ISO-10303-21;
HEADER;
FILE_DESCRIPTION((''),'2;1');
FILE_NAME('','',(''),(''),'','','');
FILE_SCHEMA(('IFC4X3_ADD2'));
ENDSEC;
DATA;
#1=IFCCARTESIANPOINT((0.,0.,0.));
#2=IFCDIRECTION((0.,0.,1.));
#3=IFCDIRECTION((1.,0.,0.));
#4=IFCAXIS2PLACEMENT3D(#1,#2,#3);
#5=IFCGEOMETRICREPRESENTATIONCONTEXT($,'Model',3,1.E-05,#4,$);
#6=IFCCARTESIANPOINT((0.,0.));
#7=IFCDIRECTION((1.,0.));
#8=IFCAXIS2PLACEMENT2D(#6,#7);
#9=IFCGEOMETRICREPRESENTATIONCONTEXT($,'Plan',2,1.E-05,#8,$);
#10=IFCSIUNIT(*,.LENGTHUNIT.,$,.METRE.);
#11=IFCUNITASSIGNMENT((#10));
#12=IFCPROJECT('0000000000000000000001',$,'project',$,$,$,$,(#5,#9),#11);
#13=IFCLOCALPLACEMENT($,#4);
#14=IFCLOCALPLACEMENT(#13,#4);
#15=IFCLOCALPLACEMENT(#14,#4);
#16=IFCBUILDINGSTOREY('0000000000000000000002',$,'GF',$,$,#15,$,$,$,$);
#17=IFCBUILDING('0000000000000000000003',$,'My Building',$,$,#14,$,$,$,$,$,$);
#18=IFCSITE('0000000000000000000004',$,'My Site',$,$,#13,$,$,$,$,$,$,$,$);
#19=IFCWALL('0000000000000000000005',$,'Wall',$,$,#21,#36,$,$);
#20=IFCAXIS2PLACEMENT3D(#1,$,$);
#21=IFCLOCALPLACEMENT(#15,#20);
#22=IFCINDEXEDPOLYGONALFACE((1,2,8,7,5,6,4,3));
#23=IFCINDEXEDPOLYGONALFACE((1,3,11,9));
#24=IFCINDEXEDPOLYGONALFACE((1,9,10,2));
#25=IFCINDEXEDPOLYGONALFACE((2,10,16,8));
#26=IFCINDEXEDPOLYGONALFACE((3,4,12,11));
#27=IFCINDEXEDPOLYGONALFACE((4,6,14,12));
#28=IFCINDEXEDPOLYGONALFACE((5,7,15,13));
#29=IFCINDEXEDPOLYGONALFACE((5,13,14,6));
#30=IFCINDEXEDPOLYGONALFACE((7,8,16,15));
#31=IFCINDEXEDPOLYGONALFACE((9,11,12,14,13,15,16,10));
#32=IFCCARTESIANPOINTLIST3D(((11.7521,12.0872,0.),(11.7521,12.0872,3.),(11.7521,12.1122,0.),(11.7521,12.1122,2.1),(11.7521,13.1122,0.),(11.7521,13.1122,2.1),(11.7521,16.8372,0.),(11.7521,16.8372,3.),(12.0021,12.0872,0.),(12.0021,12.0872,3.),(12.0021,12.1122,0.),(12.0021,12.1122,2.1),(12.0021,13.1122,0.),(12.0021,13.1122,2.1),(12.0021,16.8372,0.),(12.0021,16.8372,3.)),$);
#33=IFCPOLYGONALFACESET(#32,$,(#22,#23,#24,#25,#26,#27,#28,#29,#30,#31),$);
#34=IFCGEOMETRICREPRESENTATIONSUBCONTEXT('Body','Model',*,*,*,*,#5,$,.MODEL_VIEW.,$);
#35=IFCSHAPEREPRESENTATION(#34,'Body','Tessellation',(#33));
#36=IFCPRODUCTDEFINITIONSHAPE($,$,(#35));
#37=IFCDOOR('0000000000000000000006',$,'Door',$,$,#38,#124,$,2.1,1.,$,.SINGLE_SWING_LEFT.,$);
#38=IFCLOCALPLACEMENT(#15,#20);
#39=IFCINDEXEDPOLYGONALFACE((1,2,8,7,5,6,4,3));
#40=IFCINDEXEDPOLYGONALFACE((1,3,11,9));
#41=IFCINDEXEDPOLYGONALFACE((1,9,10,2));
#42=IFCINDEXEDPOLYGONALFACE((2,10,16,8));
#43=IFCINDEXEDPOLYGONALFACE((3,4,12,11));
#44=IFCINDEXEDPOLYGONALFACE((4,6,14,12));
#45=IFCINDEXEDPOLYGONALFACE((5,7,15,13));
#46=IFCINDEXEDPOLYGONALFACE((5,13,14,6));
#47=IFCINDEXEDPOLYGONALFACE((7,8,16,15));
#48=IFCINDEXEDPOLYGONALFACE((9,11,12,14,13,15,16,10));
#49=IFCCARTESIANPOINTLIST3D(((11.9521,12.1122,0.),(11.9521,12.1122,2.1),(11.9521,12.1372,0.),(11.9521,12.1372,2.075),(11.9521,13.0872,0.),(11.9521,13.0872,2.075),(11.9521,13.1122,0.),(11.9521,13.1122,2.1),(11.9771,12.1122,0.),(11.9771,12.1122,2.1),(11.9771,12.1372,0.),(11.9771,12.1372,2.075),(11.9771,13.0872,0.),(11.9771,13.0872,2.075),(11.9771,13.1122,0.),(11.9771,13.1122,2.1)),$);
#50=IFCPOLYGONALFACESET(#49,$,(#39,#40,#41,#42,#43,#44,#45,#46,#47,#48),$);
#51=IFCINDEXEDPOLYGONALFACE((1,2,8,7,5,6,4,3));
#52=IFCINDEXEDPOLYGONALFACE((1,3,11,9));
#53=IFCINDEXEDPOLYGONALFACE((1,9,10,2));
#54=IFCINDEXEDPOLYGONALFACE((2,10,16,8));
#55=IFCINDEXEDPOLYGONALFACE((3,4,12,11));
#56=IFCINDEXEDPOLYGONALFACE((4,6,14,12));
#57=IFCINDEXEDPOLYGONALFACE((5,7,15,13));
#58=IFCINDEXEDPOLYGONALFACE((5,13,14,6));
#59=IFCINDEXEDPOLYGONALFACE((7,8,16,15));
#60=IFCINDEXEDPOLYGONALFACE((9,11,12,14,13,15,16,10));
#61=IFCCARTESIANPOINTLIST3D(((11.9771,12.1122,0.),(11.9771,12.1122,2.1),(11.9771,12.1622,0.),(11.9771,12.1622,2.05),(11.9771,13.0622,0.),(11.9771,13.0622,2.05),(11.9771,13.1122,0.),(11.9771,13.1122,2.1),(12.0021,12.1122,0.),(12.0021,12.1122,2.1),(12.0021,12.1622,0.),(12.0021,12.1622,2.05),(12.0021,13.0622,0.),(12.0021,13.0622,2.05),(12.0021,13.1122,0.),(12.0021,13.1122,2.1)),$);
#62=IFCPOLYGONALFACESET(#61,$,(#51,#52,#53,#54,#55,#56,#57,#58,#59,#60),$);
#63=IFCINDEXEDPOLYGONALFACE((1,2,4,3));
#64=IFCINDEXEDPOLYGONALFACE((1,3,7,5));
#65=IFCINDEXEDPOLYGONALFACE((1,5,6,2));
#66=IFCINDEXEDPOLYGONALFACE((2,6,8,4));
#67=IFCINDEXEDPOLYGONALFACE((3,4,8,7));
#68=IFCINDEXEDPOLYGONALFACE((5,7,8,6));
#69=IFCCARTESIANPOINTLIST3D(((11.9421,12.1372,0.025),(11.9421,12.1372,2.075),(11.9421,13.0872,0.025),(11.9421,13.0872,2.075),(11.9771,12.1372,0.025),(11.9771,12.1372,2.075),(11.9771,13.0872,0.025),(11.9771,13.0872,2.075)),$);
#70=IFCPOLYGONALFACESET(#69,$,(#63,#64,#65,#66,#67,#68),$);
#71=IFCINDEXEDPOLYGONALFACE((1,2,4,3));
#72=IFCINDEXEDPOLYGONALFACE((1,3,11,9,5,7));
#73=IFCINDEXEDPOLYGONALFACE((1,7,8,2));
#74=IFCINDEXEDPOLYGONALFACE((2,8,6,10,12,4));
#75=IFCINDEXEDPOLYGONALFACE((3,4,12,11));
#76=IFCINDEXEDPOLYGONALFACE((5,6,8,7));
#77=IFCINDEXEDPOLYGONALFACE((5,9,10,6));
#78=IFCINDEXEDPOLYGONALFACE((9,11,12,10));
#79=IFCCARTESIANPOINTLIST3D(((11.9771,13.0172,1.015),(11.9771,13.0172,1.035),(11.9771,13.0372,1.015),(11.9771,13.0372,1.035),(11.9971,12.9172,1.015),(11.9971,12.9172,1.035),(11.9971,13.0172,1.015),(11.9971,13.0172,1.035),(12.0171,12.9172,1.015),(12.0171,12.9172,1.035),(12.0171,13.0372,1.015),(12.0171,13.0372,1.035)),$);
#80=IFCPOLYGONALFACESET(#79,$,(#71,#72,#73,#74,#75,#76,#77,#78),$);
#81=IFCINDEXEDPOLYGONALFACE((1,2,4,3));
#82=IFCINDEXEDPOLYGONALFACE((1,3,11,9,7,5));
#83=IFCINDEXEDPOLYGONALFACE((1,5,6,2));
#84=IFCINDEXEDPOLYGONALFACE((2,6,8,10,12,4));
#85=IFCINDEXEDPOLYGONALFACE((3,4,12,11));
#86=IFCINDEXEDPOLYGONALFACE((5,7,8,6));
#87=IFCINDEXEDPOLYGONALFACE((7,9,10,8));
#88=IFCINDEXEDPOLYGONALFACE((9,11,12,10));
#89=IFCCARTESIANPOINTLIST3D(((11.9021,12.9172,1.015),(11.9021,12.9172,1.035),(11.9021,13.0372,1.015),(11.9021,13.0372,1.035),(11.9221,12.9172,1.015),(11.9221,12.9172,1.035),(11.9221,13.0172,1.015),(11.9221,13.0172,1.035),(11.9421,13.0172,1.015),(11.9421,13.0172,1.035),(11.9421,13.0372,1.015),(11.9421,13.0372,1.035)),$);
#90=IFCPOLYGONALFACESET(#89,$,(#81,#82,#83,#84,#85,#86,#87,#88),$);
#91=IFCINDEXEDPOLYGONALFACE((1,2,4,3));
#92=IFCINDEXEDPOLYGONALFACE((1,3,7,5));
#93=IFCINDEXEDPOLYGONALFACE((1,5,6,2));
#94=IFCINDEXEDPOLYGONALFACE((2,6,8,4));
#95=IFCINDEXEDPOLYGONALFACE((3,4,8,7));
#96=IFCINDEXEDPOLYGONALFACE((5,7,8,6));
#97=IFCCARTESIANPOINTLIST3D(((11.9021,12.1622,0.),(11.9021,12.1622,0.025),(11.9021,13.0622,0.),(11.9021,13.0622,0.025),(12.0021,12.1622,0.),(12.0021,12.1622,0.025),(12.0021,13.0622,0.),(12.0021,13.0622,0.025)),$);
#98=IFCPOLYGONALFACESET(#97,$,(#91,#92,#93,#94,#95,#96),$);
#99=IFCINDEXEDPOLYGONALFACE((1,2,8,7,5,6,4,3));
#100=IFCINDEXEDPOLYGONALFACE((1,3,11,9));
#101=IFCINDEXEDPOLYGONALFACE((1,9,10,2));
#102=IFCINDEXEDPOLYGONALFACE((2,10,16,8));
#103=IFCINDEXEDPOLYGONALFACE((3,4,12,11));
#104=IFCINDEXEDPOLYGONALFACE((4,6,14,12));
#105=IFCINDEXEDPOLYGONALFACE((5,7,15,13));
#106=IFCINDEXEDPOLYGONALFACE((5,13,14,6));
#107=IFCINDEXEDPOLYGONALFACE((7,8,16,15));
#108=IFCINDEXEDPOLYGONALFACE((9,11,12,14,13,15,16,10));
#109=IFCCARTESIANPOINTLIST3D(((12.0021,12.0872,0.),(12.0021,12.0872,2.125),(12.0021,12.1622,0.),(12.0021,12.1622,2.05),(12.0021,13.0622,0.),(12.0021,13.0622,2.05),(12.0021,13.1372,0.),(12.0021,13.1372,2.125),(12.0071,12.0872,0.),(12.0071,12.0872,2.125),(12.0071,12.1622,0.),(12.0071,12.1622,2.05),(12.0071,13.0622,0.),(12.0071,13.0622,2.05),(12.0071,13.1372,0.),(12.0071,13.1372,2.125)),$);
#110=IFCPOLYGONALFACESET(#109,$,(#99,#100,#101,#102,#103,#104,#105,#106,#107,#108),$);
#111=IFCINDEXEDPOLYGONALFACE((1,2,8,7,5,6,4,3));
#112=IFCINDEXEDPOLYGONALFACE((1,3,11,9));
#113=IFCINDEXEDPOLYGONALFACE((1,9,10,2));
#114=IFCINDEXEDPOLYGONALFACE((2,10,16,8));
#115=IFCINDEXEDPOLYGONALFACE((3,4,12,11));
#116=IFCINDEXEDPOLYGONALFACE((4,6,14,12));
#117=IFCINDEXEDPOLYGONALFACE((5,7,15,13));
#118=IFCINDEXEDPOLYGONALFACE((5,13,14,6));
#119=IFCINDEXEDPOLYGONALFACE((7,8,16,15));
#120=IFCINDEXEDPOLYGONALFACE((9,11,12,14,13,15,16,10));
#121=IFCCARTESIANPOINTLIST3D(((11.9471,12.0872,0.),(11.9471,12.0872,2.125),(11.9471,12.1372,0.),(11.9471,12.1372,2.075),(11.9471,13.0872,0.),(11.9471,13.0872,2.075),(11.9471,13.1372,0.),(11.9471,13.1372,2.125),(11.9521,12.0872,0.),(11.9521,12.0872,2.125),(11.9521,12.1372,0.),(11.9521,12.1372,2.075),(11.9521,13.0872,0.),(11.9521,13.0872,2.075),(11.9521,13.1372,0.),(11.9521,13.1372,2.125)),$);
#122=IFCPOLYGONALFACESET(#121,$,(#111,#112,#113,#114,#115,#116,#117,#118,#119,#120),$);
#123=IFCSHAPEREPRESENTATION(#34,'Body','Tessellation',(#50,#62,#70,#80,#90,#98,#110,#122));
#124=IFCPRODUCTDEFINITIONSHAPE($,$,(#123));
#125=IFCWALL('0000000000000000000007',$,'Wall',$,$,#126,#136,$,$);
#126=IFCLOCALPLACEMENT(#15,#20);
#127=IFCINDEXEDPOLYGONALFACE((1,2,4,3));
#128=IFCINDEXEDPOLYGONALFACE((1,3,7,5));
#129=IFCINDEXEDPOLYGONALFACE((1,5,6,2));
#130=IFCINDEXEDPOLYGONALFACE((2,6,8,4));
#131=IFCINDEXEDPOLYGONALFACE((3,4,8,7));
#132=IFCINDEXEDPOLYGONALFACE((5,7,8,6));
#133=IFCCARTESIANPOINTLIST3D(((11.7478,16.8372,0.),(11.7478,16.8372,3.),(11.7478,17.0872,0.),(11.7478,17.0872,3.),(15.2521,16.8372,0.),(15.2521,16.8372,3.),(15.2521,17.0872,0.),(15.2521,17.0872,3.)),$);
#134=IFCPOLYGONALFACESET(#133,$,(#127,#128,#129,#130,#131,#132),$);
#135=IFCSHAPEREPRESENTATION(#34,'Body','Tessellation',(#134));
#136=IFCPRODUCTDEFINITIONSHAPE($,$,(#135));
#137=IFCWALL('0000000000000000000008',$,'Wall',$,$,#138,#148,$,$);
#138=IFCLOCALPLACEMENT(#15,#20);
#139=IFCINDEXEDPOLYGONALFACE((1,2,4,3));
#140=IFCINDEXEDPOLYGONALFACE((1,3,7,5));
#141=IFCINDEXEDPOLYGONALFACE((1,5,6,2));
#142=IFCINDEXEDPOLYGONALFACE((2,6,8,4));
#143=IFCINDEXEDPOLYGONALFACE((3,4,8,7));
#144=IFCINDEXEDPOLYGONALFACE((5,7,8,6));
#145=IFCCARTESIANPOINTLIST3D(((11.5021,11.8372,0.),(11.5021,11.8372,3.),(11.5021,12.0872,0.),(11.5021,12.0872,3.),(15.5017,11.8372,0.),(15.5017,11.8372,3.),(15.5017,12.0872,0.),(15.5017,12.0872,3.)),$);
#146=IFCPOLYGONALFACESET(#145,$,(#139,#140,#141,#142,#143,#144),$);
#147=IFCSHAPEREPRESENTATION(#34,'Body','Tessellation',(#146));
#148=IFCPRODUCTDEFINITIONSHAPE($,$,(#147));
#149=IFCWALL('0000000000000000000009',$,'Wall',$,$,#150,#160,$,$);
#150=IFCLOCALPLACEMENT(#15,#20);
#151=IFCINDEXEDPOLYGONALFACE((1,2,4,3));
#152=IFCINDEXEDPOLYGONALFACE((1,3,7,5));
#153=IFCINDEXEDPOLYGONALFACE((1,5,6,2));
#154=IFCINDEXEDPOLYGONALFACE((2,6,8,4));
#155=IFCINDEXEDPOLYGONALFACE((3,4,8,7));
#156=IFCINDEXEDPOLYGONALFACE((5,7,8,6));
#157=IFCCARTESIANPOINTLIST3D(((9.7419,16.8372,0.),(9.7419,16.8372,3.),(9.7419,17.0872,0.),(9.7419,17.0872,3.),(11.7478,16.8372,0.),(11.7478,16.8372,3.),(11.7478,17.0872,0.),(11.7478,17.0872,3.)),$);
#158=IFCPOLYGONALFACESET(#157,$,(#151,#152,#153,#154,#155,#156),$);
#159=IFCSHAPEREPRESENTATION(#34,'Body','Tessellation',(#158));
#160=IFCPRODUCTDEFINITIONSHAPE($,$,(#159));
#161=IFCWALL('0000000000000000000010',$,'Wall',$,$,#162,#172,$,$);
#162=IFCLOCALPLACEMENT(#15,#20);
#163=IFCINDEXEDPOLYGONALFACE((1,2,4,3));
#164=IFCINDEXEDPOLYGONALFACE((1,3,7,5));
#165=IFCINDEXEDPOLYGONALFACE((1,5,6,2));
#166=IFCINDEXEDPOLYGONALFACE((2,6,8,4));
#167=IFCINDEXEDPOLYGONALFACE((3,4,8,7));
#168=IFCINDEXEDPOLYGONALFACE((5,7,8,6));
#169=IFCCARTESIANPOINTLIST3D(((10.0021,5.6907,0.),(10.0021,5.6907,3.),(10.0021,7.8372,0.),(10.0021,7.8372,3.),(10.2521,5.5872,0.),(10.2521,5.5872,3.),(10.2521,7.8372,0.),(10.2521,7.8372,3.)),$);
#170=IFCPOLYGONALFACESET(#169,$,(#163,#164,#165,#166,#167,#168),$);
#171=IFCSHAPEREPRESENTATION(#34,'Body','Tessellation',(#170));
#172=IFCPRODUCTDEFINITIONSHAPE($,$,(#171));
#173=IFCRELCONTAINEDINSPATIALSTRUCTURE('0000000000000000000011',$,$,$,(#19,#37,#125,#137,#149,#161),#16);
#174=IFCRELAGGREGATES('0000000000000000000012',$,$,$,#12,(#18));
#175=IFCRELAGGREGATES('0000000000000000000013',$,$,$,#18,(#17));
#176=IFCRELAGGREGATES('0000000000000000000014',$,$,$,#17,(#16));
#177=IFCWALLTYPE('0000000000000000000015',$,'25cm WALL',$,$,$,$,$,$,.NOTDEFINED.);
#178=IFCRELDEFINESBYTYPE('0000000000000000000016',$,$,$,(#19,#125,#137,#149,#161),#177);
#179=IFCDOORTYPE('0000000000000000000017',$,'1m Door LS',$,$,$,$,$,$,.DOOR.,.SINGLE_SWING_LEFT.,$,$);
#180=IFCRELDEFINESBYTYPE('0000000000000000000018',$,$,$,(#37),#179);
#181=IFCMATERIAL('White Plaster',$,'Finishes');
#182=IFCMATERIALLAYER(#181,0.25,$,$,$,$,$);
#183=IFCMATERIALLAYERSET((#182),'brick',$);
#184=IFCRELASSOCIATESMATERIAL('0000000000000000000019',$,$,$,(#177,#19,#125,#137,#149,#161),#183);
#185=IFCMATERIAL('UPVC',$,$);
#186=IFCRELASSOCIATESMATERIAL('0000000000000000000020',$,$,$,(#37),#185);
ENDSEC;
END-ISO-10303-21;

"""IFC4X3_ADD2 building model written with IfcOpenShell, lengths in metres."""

from ifc_helpers import new_model, entity, si_unit, frame, origin_with_axes, origin_2d_with_axis, place, context, subcontext, project, spatial, line, indexed_curve, outline, extrude, shape, source, transform, mapped, material, layer, layer_set, layer_usage, type_object, type_shapes, element, fill, save


model = new_model("IFC4X3_ADD2")

# Units and contexts
model_context = context("Model", 3, precision=1e-05, world=origin_with_axes())
plan_context = context("Plan", 2, precision=1e-05, world=origin_2d_with_axis())
body_context_1 = subcontext(model_context, "Body", "Model", "MODEL_VIEW")
body_context_2 = subcontext(plan_context, "Body", "Plan", "PLAN_VIEW")
ifc_project = project(units=[si_unit("LENGTHUNIT", "METRE")], contexts=[model_context, plan_context])

# Site, building, storey
site_placement = place(None, origin_with_axes())
site = spatial("IfcSite", under=ifc_project, at=site_placement, Name="My Site")
building_placement = place(site_placement, origin_with_axes())
building = spatial("IfcBuilding", under=site, at=building_placement, Name="My Building")
storey_placement = place(building_placement, origin_with_axes())
storey = spatial("IfcBuildingStorey", under=building, at=storey_placement, Name="GF")

# Shared definitions
ifc_material_1 = material(Name="White Plaster", Category="Finishes")

# Wall, opening, door
ifc_layer_1 = layer(ifc_material_1, 0.25)
ifc_layer_set_1 = layer_set([ifc_layer_1], Name="brick")
wall_type_1 = type_object("IfcWallType", Name="25cm WALL", PredefinedType="NOTDEFINED", material=ifc_layer_set_1)
shared_shape_1 = source(origin_with_axes(), body_context_1, "Body", "SweptSolid", [
    extrude(outline(indexed_curve([(0.0, 0.0), (1.0, 0.0), (1.0, 2.1), (0.0, 2.1)], segments=[line(1, 2, 3, 4, 1)])), frame((0.0, -0.6, 0.0), z_axis=(0.0, -1.0, 0.0), x_axis=(1.0, 0.0, 0.0)), (0.0, 0.0, -1.0), 1.2),
])
ifc_material_2 = material(Name="UPVC")
door_type_1 = type_object("IfcDoorType", Name="1m Door LS", OperationType="SINGLE_SWING_LEFT", PredefinedType="DOOR")
shared_shape_2 = source(origin_with_axes(), body_context_1, "Body", "SweptSolid", [
    extrude(outline(indexed_curve([(0.0, 0.0), (0.0, 2.1), (1.0, 2.1), (1.0, 0.0), (0.975, 0.0), (0.975, 2.075), (0.025, 2.075), (0.025, 0.0)], segments=[line(1, 2, 3, 4, 5, 6, 7, 8, 1)])), frame((0.0, 0.025, 0.0), z_axis=(0.0, -1.0, 0.0), x_axis=(1.0, 0.0, 0.0)), (0.0, 0.0, -1.0), 0.025),
    extrude(outline(indexed_curve([(0.0, 0.0), (0.0, 2.1), (1.0, 2.1), (1.0, 0.0), (0.95, 0.0), (0.95, 2.05), (0.05, 2.05), (0.05, 0.0)], segments=[line(1, 2, 3, 4, 5, 6, 7, 8, 1)])), frame((0.0, 0.0, 0.0), z_axis=(0.0, -1.0, 0.0), x_axis=(1.0, 0.0, 0.0)), (0.0, 0.0, -1.0), 0.025),
    extrude(outline(indexed_curve([(0.0, 0.0), (0.95, 0.0), (0.95, 0.035), (0.0, 0.035)], segments=[line(1, 2, 3, 4, 1)])), frame((0.025, 0.025, 0.025), z_axis=(0.0, 0.0, 1.0), x_axis=(1.0, 0.0, 0.0)), (0.0, 0.0, 1.0), 2.05),
    extrude(outline(indexed_curve([(0.0, 0.0), (0.0, -0.04), (-0.12, -0.04), (-0.12, -0.02), (-0.02, -0.02), (-0.02, 0.0)], segments=[line(1, 2, 3, 4, 5, 6, 1)])), frame((0.925, 0.025, 1.015), z_axis=(0.0, 0.0, 1.0), x_axis=(1.0, 0.0, 0.0)), (0.0, 0.0, 1.0), 0.02),
    extrude(outline(indexed_curve([(0.0, 0.0), (0.0, 0.04), (-0.12, 0.04), (-0.12, 0.02), (-0.02, 0.02), (-0.02, 0.0)], segments=[line(1, 2, 3, 4, 5, 6, 1)])), frame((0.925, 0.06, 1.015), z_axis=(0.0, 0.0, 1.0), x_axis=(1.0, 0.0, 0.0)), (0.0, 0.0, 1.0), 0.02),
    extrude(outline(indexed_curve([(0.0, 0.0), (0.9, 0.0), (0.9, 0.1), (0.0, 0.1)], segments=[line(1, 2, 3, 4, 1)])), frame((0.05, 0.0, 0.0), z_axis=(0.0, 0.0, 1.0), x_axis=(1.0, 0.0, 0.0)), (0.0, 0.0, 1.0), 0.025),
    extrude(outline(indexed_curve([(0.0, 0.0), (0.0, 2.125), (1.05, 2.125), (1.05, 0.0), (0.975, 0.0), (0.975, 2.05), (0.075, 2.05), (0.075, 0.0)], segments=[line(1, 2, 3, 4, 5, 6, 7, 8, 1)])), frame((-0.025, -0.005, 0.0), z_axis=(0.0, -1.0, 0.0), x_axis=(1.0, 0.0, 0.0)), (0.0, 0.0, -1.0), 0.005),
    extrude(outline(indexed_curve([(0.0, 0.0), (0.0, 2.125), (1.05, 2.125), (1.05, 0.0), (1.0, 0.0), (1.0, 2.075), (0.05, 2.075), (0.05, 0.0)], segments=[line(1, 2, 3, 4, 5, 6, 7, 8, 1)])), frame((-0.025, 0.05, 0.0), z_axis=(0.0, -1.0, 0.0), x_axis=(1.0, 0.0, 0.0)), (0.0, 0.0, -1.0), 0.005),
])
shared_shape_3 = source(origin_with_axes(), body_context_2, "Body", "Curve2D", [
    entity("IfcIndexedPolyCurve", entity("IfcCartesianPointList2D", [[0.0, 0.0], [0.0, 0.05], [0.025, 0.05], [0.025, 0.025], [0.05, 0.025], [0.05, 0.0]]), [entity("IfcLineIndex", [1, 2, 3, 4, 5, 6, 1])]),
    entity("IfcIndexedPolyCurve", entity("IfcCartesianPointList2D", [[1.0, 0.0], [1.0, 0.05], [0.975, 0.05], [0.975, 0.025], [0.95, 0.025], [0.95, 0.0]]), [entity("IfcLineIndex", [1, 2, 3, 4, 5, 6, 1])]),
    entity("IfcTrimmedCurve", entity("IfcEllipse", entity("IfcAxis2Placement2D", entity("IfcCartesianPoint", [0.06, 0.05]), entity("IfcDirection", [1.0, 0.0])), 0.915, 0.95), [entity("IfcCartesianPoint", [0.975, 0.05])], [entity("IfcCartesianPoint", [0.06, 1.0])], True, "CARTESIAN"),
    entity("IfcIndexedPolyCurve", entity("IfcCartesianPointList2D", [[0.025, 0.05], [0.06, 0.05], [0.06, 1.0], [0.025, 1.0]]), [entity("IfcLineIndex", [1, 2, 3, 4, 1])]),
])
type_shapes(door_type_1, [shared_shape_2, shared_shape_3])
ifc_layer_usage_1 = layer_usage(ifc_layer_set_1, "AXIS2", "POSITIVE", 0.0)
wall_1_placement = place(storey_placement, frame((11.7521, 16.8372, 0.0), z_axis=(0.0, 0.0, 1.0), x_axis=(0.0, -1.0, 0.0)))
wall_1 = element("IfcWall", 1, at=wall_1_placement, inside=storey, type_object=wall_type_1, material=ifc_layer_usage_1, Name="Wall", context=body_context_1, shape_type="SweptSolid", body=[
    extrude(outline(indexed_curve([(0.0, 0.0), (0.0, 0.25), (4.75, 0.25), (4.75, 0.0)], segments=[line(1, 2, 3, 4, 1)])), origin_with_axes(), (0.0, 0.0, 1.0), 3.0),
])
opening_1_placement = place(wall_1_placement, frame((4.725, 0.25, 0.0), z_axis=(0.0, 0.0, 1.0), x_axis=(-1.0, 0.0, 0.0)))
opening_1 = element("IfcOpeningElement", 2, at=opening_1_placement, cuts=wall_1, PredefinedType="OPENING", context=body_context_1, shape_type="MappedRepresentation", body=[
    mapped(shared_shape_1, transform((0.0, 0.0, 0.0), x_axis=(1.0, 0.0, 0.0), y_axis=(0.0, 1.0, 0.0), z_axis=(0.0, 0.0, 1.0), scale=1.0)),
])
door_1_placement = place(opening_1_placement, frame((0.0, 0.0, 0.0), z_axis=(0.0, 0.0, 1.0), x_axis=(1.0, 0.0, 0.0)))
door_1 = element("IfcDoor", 3, at=door_1_placement, inside=storey, type_object=door_type_1, material=ifc_material_2, Name="Door", OperationType="SINGLE_SWING_LEFT", OverallHeight=2.1, OverallWidth=1.0, shapes=[
    shape(body_context_1, "Body", "MappedRepresentation", [mapped(shared_shape_2, transform((0.0, 0.0, 0.0), x_axis=(1.0, 0.0, 0.0), y_axis=(0.0, 1.0, 0.0), z_axis=(0.0, 0.0, 1.0), scale=1.0))]),
    shape(body_context_2, "Body", "MappedRepresentation", [mapped(shared_shape_3, transform((0.0, 0.0, 0.0), x_axis=(1.0, 0.0, 0.0), y_axis=(0.0, 1.0, 0.0), z_axis=(0.0, 0.0, 1.0), scale=1.0))]),
])
fill(opening_1, door_1)

# Walls
ifc_layer_usage_2 = layer_usage(ifc_layer_set_1, "AXIS2", "POSITIVE", 0.0)
wall_2_placement = place(storey_placement, frame((11.7478, 16.8372, 0.0), z_axis=(0.0, 0.0, 1.0), x_axis=(1.0, 0.0, 0.0)))
element("IfcWall", 4, at=wall_2_placement, inside=storey, type_object=wall_type_1, material=ifc_layer_usage_2, Name="Wall", context=body_context_1, shape_type="SweptSolid", body=[
    extrude(outline(indexed_curve([(0.0, 0.0), (0.0, 0.25), (3.5043, 0.25), (3.5043, 0.0)], segments=[line(1, 2, 3, 4, 1)])), origin_with_axes(), (0.0, 0.0, 1.0), 3.0),
])
ifc_layer_usage_3 = layer_usage(ifc_layer_set_1, "AXIS2", "POSITIVE", 0.0)
wall_3_placement = place(storey_placement, frame((11.5021, 11.8372, 0.0), z_axis=(0.0, 0.0, 1.0), x_axis=(1.0, 0.0, 0.0)))
element("IfcWall", 5, at=wall_3_placement, inside=storey, type_object=wall_type_1, material=ifc_layer_usage_3, Name="Wall", context=body_context_1, shape_type="SweptSolid", body=[
    extrude(outline(indexed_curve([(0.0, 0.0), (0.0, 0.25), (3.9996, 0.25), (3.9996, 0.0)], segments=[line(1, 2, 3, 4, 1)])), origin_with_axes(), (0.0, 0.0, 1.0), 3.0),
])
ifc_layer_usage_4 = layer_usage(ifc_layer_set_1, "AXIS2", "POSITIVE", 0.0)
wall_4_placement = place(storey_placement, frame((9.7419, 16.8372, 0.0), z_axis=(0.0, 0.0, 1.0), x_axis=(1.0, 0.0, 0.0)))
element("IfcWall", 6, at=wall_4_placement, inside=storey, type_object=wall_type_1, material=ifc_layer_usage_4, Name="Wall", context=body_context_1, shape_type="SweptSolid", body=[
    extrude(outline(indexed_curve([(0.0, 0.0), (0.0, 0.25), (2.006, 0.25), (2.006, 0.0)], segments=[line(1, 2, 3, 4, 1)])), origin_with_axes(), (0.0, 0.0, 1.0), 3.0),
])
ifc_layer_usage_5 = layer_usage(ifc_layer_set_1, "AXIS2", "POSITIVE", 0.0)
wall_5_placement = place(storey_placement, frame((10.0021, 7.8372, 0.0), z_axis=(0.0, 0.0, 1.0), x_axis=(0.0, -1.0, 0.0)))
element("IfcWall", 7, at=wall_5_placement, inside=storey, type_object=wall_type_1, material=ifc_layer_usage_5, Name="Wall", context=body_context_1, shape_type="SweptSolid", body=[
    extrude(outline(indexed_curve([(0.0, 0.0), (0.0, 0.25), (2.25, 0.25), (2.1464, 0.0)], segments=[line(1, 2, 3, 4, 1)])), origin_with_axes(), (0.0, 0.0, 1.0), 3.0),
])

save(model, "model.ifc")
